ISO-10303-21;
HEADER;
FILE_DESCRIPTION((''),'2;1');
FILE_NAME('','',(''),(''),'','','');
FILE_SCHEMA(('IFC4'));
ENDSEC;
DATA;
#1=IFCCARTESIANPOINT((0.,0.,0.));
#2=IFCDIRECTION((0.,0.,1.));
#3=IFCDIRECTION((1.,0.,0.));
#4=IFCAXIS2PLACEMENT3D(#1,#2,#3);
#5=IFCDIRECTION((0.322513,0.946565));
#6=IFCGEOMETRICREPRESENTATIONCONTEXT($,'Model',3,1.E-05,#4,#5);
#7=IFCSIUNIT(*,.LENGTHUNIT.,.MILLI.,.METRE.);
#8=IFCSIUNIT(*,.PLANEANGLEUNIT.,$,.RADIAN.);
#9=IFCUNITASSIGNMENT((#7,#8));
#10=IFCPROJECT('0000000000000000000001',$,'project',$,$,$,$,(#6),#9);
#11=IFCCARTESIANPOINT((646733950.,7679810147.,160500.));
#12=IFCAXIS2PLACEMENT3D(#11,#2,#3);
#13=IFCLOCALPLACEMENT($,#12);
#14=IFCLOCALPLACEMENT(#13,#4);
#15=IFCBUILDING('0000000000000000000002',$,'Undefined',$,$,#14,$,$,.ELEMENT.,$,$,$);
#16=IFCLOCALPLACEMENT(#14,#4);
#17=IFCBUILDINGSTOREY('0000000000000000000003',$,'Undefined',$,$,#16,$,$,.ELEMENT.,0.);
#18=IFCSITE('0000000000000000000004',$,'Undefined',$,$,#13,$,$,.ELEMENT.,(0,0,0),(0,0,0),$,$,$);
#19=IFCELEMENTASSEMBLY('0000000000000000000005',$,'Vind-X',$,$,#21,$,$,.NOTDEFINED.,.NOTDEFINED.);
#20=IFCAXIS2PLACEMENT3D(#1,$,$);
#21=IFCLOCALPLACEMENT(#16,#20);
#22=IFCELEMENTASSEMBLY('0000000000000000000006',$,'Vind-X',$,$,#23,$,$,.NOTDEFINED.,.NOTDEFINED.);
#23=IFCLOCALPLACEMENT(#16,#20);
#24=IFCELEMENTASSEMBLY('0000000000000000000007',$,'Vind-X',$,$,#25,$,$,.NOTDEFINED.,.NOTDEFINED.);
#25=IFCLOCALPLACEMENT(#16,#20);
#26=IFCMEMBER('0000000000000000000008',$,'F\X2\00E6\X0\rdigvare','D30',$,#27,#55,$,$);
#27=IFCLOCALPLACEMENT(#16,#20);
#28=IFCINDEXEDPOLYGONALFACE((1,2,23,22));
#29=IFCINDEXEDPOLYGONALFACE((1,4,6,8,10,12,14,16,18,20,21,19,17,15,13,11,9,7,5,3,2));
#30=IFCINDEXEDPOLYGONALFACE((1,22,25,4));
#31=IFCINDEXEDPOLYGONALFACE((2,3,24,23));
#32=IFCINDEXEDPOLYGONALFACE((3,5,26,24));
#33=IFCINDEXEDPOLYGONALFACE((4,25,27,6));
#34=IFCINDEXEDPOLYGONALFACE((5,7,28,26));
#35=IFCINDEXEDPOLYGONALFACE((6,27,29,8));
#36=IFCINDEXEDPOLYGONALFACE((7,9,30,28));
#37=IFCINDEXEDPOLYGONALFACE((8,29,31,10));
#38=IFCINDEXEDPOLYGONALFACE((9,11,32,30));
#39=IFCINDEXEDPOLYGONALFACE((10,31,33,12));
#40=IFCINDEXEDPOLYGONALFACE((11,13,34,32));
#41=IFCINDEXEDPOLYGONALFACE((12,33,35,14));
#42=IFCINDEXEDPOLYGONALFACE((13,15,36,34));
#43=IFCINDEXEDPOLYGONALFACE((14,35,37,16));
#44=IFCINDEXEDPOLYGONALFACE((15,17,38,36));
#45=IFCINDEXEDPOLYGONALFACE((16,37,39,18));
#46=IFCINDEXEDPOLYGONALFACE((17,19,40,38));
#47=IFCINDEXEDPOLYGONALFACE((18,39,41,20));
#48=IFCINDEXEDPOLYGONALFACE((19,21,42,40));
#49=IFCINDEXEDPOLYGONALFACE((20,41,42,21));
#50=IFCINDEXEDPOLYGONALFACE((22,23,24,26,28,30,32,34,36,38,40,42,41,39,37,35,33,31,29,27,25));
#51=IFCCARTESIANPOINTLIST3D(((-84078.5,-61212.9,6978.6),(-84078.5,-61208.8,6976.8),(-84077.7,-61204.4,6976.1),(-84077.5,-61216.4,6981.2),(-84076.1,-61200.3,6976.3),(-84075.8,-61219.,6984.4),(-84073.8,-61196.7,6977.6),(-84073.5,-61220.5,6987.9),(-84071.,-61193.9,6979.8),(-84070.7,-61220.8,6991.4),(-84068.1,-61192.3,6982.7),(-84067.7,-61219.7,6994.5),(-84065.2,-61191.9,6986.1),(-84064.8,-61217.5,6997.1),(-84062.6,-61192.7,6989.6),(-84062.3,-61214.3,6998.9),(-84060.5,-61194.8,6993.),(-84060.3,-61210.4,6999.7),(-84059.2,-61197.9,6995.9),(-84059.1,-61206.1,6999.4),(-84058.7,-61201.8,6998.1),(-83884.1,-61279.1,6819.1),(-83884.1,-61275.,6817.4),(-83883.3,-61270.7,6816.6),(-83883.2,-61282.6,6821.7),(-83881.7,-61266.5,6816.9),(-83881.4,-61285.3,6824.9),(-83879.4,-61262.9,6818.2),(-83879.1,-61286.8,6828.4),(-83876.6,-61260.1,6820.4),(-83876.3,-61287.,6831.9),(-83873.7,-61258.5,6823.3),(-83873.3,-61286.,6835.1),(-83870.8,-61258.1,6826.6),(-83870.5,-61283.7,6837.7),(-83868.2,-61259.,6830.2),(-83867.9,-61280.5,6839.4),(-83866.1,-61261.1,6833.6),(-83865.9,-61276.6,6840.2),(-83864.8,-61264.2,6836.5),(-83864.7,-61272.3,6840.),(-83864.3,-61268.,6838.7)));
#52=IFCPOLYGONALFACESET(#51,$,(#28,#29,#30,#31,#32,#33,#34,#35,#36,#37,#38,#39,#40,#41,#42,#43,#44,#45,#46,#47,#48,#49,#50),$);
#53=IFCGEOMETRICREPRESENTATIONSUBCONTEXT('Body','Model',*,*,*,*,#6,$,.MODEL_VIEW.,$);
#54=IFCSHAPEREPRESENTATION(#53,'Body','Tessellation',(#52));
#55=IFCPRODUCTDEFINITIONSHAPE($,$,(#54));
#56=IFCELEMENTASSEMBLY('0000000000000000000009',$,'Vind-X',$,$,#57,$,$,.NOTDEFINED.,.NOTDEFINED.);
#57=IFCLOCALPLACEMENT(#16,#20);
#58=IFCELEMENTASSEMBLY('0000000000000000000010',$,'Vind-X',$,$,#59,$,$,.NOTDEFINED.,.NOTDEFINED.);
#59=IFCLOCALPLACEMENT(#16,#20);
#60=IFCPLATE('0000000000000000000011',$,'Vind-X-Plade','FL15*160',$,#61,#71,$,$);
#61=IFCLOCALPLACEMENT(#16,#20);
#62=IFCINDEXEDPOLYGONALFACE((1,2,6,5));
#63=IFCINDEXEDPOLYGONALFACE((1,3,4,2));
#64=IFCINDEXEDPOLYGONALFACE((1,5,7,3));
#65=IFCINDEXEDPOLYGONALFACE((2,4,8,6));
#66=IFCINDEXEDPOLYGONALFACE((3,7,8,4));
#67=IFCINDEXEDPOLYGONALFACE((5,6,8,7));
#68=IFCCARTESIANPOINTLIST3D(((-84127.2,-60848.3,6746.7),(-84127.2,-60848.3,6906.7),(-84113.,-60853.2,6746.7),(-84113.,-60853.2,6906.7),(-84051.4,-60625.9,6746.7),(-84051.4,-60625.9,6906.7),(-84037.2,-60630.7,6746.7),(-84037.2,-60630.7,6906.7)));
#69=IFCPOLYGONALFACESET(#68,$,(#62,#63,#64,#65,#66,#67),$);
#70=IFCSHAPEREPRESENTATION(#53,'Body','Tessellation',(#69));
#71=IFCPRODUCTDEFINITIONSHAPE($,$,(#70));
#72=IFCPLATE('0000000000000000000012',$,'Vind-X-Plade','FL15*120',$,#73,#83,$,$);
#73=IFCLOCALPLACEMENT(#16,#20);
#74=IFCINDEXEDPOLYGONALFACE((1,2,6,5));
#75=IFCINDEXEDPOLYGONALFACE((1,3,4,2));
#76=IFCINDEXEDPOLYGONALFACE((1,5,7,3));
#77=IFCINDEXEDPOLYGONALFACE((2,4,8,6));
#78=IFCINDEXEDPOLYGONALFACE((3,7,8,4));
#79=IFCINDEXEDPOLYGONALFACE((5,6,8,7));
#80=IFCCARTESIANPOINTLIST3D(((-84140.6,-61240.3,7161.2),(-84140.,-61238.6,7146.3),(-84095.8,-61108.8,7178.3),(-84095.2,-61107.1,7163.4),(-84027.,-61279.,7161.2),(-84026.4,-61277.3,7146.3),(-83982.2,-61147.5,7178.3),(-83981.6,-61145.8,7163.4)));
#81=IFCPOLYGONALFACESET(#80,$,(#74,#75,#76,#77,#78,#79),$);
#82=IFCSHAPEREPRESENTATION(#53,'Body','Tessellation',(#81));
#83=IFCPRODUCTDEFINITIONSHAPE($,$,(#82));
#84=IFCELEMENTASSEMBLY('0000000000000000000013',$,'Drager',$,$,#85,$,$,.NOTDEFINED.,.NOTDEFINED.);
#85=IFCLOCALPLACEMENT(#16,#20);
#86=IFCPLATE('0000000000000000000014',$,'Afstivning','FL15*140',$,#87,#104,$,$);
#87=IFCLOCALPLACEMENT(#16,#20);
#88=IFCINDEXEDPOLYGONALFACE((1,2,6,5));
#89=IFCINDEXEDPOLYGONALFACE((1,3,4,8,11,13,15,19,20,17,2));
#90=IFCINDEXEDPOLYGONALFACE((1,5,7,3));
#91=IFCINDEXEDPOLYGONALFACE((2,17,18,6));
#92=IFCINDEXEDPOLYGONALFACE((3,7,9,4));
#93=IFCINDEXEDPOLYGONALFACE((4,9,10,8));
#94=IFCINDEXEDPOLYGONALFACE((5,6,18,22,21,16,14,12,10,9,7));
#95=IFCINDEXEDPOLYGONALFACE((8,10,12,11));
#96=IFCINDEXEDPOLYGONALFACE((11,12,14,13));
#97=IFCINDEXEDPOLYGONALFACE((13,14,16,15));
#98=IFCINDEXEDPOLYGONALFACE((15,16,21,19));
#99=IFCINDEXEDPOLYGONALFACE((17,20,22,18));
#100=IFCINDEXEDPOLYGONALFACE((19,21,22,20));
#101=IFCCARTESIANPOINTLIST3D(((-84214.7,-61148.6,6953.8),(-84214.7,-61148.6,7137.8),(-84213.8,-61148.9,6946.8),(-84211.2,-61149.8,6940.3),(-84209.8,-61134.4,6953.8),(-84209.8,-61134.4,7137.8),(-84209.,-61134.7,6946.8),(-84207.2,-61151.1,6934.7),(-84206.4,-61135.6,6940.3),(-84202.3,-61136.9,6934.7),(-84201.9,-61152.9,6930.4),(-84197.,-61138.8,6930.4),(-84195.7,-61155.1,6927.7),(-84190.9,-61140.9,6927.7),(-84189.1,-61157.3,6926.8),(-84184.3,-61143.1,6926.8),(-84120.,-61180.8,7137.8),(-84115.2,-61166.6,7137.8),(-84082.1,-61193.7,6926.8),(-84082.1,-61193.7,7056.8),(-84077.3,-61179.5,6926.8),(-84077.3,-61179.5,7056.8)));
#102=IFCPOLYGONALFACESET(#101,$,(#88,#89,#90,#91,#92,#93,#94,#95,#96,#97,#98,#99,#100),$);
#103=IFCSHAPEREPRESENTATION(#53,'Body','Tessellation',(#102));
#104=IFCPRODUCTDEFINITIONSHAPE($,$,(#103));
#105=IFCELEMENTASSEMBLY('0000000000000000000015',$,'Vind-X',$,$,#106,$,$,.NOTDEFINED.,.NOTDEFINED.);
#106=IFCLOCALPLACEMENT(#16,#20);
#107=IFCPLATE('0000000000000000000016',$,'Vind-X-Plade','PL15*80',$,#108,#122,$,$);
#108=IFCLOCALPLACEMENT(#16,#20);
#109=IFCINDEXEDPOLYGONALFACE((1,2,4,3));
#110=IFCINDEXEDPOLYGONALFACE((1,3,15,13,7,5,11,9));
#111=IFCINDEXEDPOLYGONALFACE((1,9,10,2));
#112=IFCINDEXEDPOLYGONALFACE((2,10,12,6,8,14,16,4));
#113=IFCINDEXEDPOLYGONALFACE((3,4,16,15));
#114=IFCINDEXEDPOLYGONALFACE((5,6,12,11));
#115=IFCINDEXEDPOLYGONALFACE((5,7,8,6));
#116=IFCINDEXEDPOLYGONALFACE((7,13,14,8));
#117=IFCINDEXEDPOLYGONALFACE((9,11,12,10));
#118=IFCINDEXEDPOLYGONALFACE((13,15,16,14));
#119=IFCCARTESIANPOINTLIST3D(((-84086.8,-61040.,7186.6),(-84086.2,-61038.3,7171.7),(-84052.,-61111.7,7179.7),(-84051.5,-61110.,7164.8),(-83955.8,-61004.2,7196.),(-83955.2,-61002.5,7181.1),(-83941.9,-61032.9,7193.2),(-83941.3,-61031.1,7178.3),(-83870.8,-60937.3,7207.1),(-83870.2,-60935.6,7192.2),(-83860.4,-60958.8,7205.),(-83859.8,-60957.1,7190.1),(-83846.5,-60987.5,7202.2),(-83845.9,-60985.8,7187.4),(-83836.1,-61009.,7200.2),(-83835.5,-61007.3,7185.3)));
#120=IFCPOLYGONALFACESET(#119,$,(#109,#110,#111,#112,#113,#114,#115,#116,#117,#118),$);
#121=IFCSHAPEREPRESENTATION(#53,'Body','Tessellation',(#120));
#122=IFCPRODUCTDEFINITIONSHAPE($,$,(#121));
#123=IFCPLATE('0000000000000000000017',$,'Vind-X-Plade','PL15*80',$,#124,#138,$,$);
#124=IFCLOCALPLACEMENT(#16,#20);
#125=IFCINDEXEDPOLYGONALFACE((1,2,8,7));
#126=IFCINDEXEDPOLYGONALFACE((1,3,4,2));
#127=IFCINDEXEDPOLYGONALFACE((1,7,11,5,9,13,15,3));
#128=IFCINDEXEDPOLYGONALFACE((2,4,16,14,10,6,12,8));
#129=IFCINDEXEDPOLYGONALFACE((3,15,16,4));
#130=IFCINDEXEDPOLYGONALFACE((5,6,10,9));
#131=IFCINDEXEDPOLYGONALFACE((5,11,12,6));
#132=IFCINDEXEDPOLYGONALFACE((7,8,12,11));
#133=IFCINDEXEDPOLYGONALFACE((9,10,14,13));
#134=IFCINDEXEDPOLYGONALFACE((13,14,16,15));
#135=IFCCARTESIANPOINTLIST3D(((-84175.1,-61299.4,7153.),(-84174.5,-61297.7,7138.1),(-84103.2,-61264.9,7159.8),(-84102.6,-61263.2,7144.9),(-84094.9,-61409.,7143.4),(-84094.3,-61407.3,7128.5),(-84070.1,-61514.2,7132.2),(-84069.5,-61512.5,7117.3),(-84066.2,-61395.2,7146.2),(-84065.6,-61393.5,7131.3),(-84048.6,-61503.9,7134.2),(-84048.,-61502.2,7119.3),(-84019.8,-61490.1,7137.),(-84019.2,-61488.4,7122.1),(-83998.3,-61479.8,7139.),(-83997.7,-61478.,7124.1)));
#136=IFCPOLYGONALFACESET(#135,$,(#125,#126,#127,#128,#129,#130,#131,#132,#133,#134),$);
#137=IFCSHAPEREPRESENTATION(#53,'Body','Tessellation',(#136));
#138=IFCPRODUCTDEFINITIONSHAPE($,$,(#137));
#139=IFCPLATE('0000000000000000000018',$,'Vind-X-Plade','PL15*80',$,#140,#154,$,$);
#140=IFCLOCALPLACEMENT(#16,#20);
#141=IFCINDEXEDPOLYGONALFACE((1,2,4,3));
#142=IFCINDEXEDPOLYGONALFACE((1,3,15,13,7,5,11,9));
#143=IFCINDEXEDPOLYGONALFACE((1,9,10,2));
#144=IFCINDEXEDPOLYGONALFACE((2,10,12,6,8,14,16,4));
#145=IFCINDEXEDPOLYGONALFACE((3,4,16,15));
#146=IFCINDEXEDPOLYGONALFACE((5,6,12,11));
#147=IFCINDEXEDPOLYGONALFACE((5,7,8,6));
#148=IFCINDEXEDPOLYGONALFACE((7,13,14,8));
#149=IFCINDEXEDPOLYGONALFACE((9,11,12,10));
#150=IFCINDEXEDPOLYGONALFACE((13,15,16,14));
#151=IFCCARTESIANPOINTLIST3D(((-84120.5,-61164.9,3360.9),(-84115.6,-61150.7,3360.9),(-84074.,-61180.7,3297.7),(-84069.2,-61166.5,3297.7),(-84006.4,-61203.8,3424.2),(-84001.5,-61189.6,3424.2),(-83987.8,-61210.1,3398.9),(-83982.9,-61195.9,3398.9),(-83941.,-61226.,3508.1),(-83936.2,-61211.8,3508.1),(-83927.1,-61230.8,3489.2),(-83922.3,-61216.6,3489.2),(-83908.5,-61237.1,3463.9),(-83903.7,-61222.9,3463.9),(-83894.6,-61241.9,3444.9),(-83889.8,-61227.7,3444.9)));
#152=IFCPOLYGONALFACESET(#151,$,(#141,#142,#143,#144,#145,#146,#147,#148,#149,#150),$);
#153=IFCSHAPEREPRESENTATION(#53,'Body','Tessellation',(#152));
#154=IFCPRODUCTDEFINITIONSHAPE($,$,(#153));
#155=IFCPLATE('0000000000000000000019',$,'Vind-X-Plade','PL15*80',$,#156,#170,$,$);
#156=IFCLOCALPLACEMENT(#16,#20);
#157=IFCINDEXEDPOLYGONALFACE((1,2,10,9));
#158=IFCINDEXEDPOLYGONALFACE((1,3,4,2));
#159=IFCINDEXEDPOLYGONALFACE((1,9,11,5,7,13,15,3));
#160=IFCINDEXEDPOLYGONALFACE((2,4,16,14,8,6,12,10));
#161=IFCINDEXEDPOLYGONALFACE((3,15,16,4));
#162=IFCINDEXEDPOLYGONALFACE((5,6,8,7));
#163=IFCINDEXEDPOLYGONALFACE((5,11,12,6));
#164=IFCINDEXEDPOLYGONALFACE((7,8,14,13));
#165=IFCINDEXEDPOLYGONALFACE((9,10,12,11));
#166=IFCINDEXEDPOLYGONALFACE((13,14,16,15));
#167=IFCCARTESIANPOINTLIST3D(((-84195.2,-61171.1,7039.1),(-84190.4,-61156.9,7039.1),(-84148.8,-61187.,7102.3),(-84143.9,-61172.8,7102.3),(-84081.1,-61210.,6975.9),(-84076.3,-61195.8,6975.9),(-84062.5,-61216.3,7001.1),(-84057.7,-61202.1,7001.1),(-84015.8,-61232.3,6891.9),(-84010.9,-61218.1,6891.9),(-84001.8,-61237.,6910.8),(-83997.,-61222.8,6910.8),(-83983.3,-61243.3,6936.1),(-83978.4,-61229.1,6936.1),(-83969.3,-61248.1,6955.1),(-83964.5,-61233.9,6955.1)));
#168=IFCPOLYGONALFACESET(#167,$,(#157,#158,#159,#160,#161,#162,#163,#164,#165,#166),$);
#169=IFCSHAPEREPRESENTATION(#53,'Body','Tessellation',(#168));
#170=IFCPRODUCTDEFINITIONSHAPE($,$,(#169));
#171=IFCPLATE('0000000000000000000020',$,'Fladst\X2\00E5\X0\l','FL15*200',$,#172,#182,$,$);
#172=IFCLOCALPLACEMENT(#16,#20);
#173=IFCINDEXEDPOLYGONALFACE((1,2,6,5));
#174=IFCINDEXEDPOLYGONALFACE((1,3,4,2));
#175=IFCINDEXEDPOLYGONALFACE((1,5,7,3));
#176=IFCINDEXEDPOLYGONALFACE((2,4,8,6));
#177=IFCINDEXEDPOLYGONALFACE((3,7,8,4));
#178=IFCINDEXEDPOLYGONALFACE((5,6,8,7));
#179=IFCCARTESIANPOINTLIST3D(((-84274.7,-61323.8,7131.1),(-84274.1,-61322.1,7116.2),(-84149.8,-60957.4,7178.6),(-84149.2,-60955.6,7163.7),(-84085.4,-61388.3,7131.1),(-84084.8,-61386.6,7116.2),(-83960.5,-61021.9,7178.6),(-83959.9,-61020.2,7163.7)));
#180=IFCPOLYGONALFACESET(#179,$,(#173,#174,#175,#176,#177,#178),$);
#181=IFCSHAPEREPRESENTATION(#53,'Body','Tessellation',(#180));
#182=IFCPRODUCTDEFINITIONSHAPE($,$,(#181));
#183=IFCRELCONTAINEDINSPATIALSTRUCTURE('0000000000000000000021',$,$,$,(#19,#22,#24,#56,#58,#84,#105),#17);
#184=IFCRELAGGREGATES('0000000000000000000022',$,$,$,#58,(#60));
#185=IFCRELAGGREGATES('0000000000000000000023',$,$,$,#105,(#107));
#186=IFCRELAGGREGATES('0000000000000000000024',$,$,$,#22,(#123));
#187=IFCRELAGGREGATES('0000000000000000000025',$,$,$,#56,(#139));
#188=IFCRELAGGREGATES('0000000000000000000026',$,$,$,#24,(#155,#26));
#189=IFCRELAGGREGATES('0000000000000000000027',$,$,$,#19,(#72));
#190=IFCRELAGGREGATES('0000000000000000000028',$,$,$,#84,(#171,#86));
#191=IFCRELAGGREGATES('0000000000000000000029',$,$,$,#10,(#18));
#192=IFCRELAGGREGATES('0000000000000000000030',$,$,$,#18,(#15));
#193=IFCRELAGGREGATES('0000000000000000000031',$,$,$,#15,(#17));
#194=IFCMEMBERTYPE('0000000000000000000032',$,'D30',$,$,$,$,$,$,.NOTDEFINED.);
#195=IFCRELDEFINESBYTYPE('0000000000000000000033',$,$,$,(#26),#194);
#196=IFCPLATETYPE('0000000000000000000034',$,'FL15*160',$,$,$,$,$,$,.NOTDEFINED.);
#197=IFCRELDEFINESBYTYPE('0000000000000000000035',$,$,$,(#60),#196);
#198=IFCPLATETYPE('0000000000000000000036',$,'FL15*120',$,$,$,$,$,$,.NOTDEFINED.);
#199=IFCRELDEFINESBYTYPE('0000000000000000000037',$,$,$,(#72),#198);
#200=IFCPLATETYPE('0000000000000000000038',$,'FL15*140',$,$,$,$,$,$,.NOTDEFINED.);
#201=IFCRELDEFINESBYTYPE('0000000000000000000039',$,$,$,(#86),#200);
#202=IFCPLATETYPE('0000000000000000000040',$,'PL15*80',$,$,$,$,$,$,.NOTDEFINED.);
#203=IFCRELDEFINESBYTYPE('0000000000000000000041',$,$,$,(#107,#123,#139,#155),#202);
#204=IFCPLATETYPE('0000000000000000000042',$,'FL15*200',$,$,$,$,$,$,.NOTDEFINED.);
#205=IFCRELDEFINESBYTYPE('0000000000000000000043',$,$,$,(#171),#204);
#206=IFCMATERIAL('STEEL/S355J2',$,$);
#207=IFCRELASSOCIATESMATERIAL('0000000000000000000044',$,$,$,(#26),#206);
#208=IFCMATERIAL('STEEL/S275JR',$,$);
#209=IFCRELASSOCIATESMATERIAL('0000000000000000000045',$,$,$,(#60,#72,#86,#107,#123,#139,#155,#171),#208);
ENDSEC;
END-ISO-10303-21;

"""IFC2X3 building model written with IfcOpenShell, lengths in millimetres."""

from ifc_helpers import new_model, si_unit, direction, frame, frame_2d, origin_with_axes, origin_2d_with_axis, place, context, subcontext, project, spatial, polyline, circle_curve, parameter, trimmed, segment, composite_curve, circle, outline, extrude, boolean, material, type_object, element, aggregate, save


model = new_model("IFC2X3")

# Units and contexts
model_context = context("Model", 3, precision=1e-05, world=origin_with_axes(), true_north=direction((0.322513, 0.946565)))
body_context = subcontext(model_context, "Body", "Model", "MODEL_VIEW")
ifc_project = project(units=[si_unit("LENGTHUNIT", "METRE", prefix="MILLI"), si_unit("PLANEANGLEUNIT", "RADIAN")], contexts=[model_context])

# Site, building, storey
site_placement = place(None, frame((646733950.0, 7679810147.0, 160500.0), z_axis=(0.0, 0.0, 1.0), x_axis=(1.0, 0.0, 0.0)))
site = spatial("IfcSite", under=ifc_project, at=site_placement, Name="Undefined", CompositionType="ELEMENT", RefLatitude=(0, 0, 0), RefLongitude=(0, 0, 0))
building_placement = place(site_placement, origin_with_axes())
building = spatial("IfcBuilding", under=site, at=building_placement, Name="Undefined", CompositionType="ELEMENT")
storey_placement = place(building_placement, origin_with_axes())
storey = spatial("IfcBuildingStorey", under=building, at=storey_placement, Name="Undefined", CompositionType="ELEMENT", Elevation=0.0)

# Element assembly
assembly_1_placement = place(storey_placement, origin_with_axes())
assembly_1 = element("IfcElementAssembly", 1, at=assembly_1_placement, inside=storey, Name="Vind-X", AssemblyPlace="NOTDEFINED", PredefinedType="NOTDEFINED")

# Element assemblies, member
assembly_2_placement = place(storey_placement, origin_with_axes())
assembly_2 = element("IfcElementAssembly", 2, at=assembly_2_placement, inside=storey, Name="Vind-X", AssemblyPlace="NOTDEFINED", PredefinedType="NOTDEFINED")
ifc_material_1 = material(Name="STEEL/S355J2")
member_type = type_object("IfcMemberType", Name="D30", PredefinedType="NOTDEFINED")
assembly_3_placement = place(storey_placement, origin_with_axes())
assembly_3 = element("IfcElementAssembly", 3, at=assembly_3_placement, inside=storey, Name="Vind-X", AssemblyPlace="NOTDEFINED", PredefinedType="NOTDEFINED")
member_1_placement = place(assembly_3_placement, frame((-84068.6, -61206.3, 6987.9), z_axis=(0.580542, -0.197802, 0.789839), x_axis=(0.747634, -0.254733, -0.613314)))
member_1 = element("IfcMember", 4, at=member_1_placement, type_object=member_type, material=ifc_material_1, Name="Færdigvare", Description="D30", context=body_context, shape_type="SweptSolid", body=[
    extrude(circle(Radius=15.0, at=origin_2d_with_axis()), frame((260.0, 0.0, 0.0), z_axis=(-1.0, 0.0, 0.0), x_axis=(0.0, -1.0, 0.0)), (0.0, 0.0, 1.0), 260.0),
])
assembly_4_placement = place(storey_placement, origin_with_axes())
assembly_4 = element("IfcElementAssembly", 5, at=assembly_4_placement, inside=storey, Name="Vind-X", AssemblyPlace="NOTDEFINED", PredefinedType="NOTDEFINED")

# Element assembly, plate
assembly_5_placement = place(storey_placement, origin_with_axes())
assembly_5 = element("IfcElementAssembly", 6, at=assembly_5_placement, inside=storey, Name="Vind-X", AssemblyPlace="NOTDEFINED", PredefinedType="NOTDEFINED")
ifc_material_2 = material(Name="STEEL/S275JR")
plate_type_1 = type_object("IfcPlateType", Name="FL15*160", PredefinedType="NOTDEFINED")
plate_1_placement = place(assembly_5_placement, frame((-84120.1, -60850.7, 6826.7), z_axis=(0.946565, -0.322513, 0.0), x_axis=(0.322513, 0.946565, 0.0)))
plate_1 = element("IfcPlate", 7, at=plate_1_placement, type_object=plate_type_1, material=ifc_material_2, Name="Vind-X-Plade", Description="FL15*160", context=body_context, shape_type="SweptSolid", body=[
    extrude(outline(polyline([(0.0, -80.0), (0.0, 80.0), (235.0, 80.0), (235.0, -80.0), (0.0, -80.0)])), frame((0.0, 0.0, -7.5), z_axis=(0.0, 0.0, 1.0), x_axis=(1.0, 0.0, 0.0)), (0.0, 0.0, 1.0), 15.0),
])

# Plate
plate_type_2 = type_object("IfcPlateType", Name="FL15*120", PredefinedType="NOTDEFINED")
plate_2_placement = place(assembly_1_placement, frame((-84117.9, -61173.7, 7162.3), z_axis=(0.039304, 0.115357, -0.992546), x_axis=(0.946565, -0.322513, 0.0)))
plate_2 = element("IfcPlate", 8, at=plate_2_placement, type_object=plate_type_2, material=ifc_material_2, Name="Vind-X-Plade", Description="FL15*120", context=body_context, shape_type="SweptSolid", body=[
    extrude(outline(polyline([(0.0, -70.0), (0.0, 70.0), (120.0, 70.0), (120.0, -70.0), (0.0, -70.0)])), frame((0.0, 0.0, -7.5), z_axis=(0.0, 0.0, 1.0), x_axis=(1.0, 0.0, 0.0)), (0.0, 0.0, 1.0), 15.0),
])

# Element assemblies, plates
assembly_6_placement = place(storey_placement, origin_with_axes())
assembly_6 = element("IfcElementAssembly", 9, at=assembly_6_placement, inside=storey, Name="Drager", AssemblyPlace="NOTDEFINED", PredefinedType="NOTDEFINED")
plate_type_3 = type_object("IfcPlateType", Name="FL15*140", PredefinedType="NOTDEFINED")
plate_3_placement = place(assembly_6_placement, frame((-84212.2, -61141.5, 6926.8), z_axis=(-0.322513, -0.946565, 0.0), x_axis=(0.946565, -0.322513, 0.0)))
plate_3 = element("IfcPlate", 10, at=plate_3_placement, type_object=plate_type_3, material=ifc_material_2, Name="Afstivning", Description="FL15*140", context=body_context, shape_type="SweptSolid", body=[
    extrude(outline(composite_curve([segment(trimmed(circle_curve(frame_2d((27.0, 27.0), x_axis=(-1.0, 0.0)), 27.0), [parameter(0.0)], [parameter(1.570796)], True, "PARAMETER"), True, "CONTINUOUS"), segment(polyline([(27.0, 0.0), (140.0, 0.0), (140.0, 130.0), (100.0, 211.0), (0.0, 211.0), (0.0, 27.0)]), True, "CONTINUOUS")], self_intersect=True)), frame((0.0, 0.0, -7.5), z_axis=(0.0, 0.0, 1.0), x_axis=(1.0, 0.0, 0.0)), (0.0, 0.0, 1.0), 15.0),
])
assembly_7_placement = place(storey_placement, origin_with_axes())
assembly_7 = element("IfcElementAssembly", 11, at=assembly_7_placement, inside=storey, Name="Vind-X", AssemblyPlace="NOTDEFINED", PredefinedType="NOTDEFINED")
plate_type_4 = type_object("IfcPlateType", Name="PL15*80", PredefinedType="NOTDEFINED")
plate_4_placement = place(assembly_7_placement, frame((-84051.7, -61110.8, 7172.2), z_axis=(0.039304, 0.115357, -0.992546), x_axis=(-0.434441, 0.89649, 0.08699)))
plate_4 = element("IfcPlate", 12, at=plate_4_placement, type_object=plate_type_4, material=ifc_material_2, Name="Vind-X-Plade", Description="PL15*80", context=body_context, shape_type="CSG", body=[
    boolean("DIFFERENCE", extrude(outline(polyline([(0.0, 0.0), (80.0, 0.0), (80.0, 240.0), (0.0, 240.0), (0.0, 0.0)])), frame((0.0, 0.0, -7.5), z_axis=(0.0, 0.0, 1.0), x_axis=(1.0, 0.0, 0.0)), (0.0, 0.0, 1.0), 15.0), extrude(outline(polyline([(0.0, 0.0), (106.0, 0.0), (106.0, 32.0), (0.0, 32.0), (0.0, 0.0)])), frame((56.0, 240.0, 8.5), z_axis=(0.0, 0.0, -1.0), x_axis=(0.0, -1.0, 0.0)), (0.0, 0.0, 1.0), 17.0)),
])

# Plates
plate_5_placement = place(assembly_2_placement, frame((-84174.8, -61298.5, 7145.5), z_axis=(0.039304, 0.115357, -0.992546), x_axis=(0.898474, 0.430595, 0.085625)))
plate_5 = element("IfcPlate", 13, at=plate_5_placement, type_object=plate_type_4, material=ifc_material_2, Name="Vind-X-Plade", Description="PL15*80", context=body_context, shape_type="CSG", body=[
    boolean("DIFFERENCE", extrude(outline(polyline([(0.0, 0.0), (80.0, 0.0), (80.0, 240.0), (0.0, 240.0), (0.0, 0.0)])), frame((0.0, 0.0, -7.5), z_axis=(0.0, 0.0, 1.0), x_axis=(1.0, 0.0, 0.0)), (0.0, 0.0, 1.0), 15.0), extrude(outline(polyline([(0.0, 0.0), (106.0, 0.0), (106.0, 32.0), (0.0, 32.0), (0.0, 0.0)])), frame((56.0, 240.0, 8.5), z_axis=(0.0, 0.0, -1.0), x_axis=(0.0, -1.0, 0.0)), (0.0, 0.0, 1.0), 17.0)),
])
plate_6_placement = place(assembly_4_placement, frame((-84071.6, -61173.6, 3297.7), z_axis=(0.322513, 0.946565, 0.0), x_axis=(-0.580575, 0.197813, 0.789812)))
plate_6 = element("IfcPlate", 14, at=plate_6_placement, type_object=plate_type_4, material=ifc_material_2, Name="Vind-X-Plade", Description="PL15*80", context=body_context, shape_type="CSG", body=[
    boolean("DIFFERENCE", extrude(outline(polyline([(0.0, 0.0), (80.0, 0.0), (80.0, 240.0), (0.0, 240.0), (0.0, 0.0)])), frame((0.0, 0.0, -7.5), z_axis=(0.0, 0.0, 1.0), x_axis=(1.0, 0.0, 0.0)), (0.0, 0.0, 1.0), 15.0), extrude(outline(polyline([(0.0, 0.0), (106.0, 0.0), (106.0, 32.0), (0.0, 32.0), (0.0, 0.0)])), frame((56.0, 240.0, 8.5), z_axis=(0.0, 0.0, -1.0), x_axis=(0.0, -1.0, 0.0)), (0.0, 0.0, 1.0), 17.0)),
])
plate_7_placement = place(assembly_3_placement, frame((-84192.8, -61164.0, 7039.1), z_axis=(0.322513, 0.946565, 0.0), x_axis=(0.580542, -0.197802, 0.789839)))
plate_7 = element("IfcPlate", 15, at=plate_7_placement, type_object=plate_type_4, material=ifc_material_2, Name="Vind-X-Plade", Description="PL15*80", context=body_context, shape_type="CSG", body=[
    boolean("DIFFERENCE", extrude(outline(polyline([(0.0, 0.0), (80.0, 0.0), (80.0, 240.0), (0.0, 240.0), (0.0, 0.0)])), frame((0.0, 0.0, -7.5), z_axis=(0.0, 0.0, 1.0), x_axis=(1.0, 0.0, 0.0)), (0.0, 0.0, 1.0), 15.0), extrude(outline(polyline([(0.0, 0.0), (106.0, 0.0), (106.0, 32.0), (0.0, 32.0), (0.0, 0.0)])), frame((56.0, 240.0, 8.5), z_axis=(0.0, 0.0, -1.0), x_axis=(0.0, -1.0, 0.0)), (0.0, 0.0, 1.0), 17.0)),
])
plate_type_5 = type_object("IfcPlateType", Name="FL15*200", PredefinedType="NOTDEFINED")
plate_8_placement = place(assembly_6_placement, frame((-84149.5, -60956.5, 7171.2), z_axis=(-0.039304, -0.115357, 0.992546), x_axis=(-0.320109, -0.93951, -0.121869)))
plate_8 = element("IfcPlate", 16, at=plate_8_placement, type_object=plate_type_5, material=ifc_material_2, Name="Fladstål", Description="FL15*200", context=body_context, shape_type="SweptSolid", body=[
    extrude(outline(polyline([(0.0, 0.0), (390.0, 0.0), (390.0, 200.0), (0.0, 200.0), (0.0, 0.0)])), frame((0.0, 0.0, -7.5), z_axis=(0.0, 0.0, 1.0), x_axis=(1.0, 0.0, 0.0)), (0.0, 0.0, 1.0), 15.0),
])

aggregate(assembly_5, [plate_1])

aggregate(assembly_7, [plate_4])
aggregate(assembly_2, [plate_5])
aggregate(assembly_4, [plate_6])
aggregate(assembly_3, [plate_7, member_1])
aggregate(assembly_1, [plate_2])
aggregate(assembly_6, [plate_8, plate_3])

save(model, "model.ifc")
